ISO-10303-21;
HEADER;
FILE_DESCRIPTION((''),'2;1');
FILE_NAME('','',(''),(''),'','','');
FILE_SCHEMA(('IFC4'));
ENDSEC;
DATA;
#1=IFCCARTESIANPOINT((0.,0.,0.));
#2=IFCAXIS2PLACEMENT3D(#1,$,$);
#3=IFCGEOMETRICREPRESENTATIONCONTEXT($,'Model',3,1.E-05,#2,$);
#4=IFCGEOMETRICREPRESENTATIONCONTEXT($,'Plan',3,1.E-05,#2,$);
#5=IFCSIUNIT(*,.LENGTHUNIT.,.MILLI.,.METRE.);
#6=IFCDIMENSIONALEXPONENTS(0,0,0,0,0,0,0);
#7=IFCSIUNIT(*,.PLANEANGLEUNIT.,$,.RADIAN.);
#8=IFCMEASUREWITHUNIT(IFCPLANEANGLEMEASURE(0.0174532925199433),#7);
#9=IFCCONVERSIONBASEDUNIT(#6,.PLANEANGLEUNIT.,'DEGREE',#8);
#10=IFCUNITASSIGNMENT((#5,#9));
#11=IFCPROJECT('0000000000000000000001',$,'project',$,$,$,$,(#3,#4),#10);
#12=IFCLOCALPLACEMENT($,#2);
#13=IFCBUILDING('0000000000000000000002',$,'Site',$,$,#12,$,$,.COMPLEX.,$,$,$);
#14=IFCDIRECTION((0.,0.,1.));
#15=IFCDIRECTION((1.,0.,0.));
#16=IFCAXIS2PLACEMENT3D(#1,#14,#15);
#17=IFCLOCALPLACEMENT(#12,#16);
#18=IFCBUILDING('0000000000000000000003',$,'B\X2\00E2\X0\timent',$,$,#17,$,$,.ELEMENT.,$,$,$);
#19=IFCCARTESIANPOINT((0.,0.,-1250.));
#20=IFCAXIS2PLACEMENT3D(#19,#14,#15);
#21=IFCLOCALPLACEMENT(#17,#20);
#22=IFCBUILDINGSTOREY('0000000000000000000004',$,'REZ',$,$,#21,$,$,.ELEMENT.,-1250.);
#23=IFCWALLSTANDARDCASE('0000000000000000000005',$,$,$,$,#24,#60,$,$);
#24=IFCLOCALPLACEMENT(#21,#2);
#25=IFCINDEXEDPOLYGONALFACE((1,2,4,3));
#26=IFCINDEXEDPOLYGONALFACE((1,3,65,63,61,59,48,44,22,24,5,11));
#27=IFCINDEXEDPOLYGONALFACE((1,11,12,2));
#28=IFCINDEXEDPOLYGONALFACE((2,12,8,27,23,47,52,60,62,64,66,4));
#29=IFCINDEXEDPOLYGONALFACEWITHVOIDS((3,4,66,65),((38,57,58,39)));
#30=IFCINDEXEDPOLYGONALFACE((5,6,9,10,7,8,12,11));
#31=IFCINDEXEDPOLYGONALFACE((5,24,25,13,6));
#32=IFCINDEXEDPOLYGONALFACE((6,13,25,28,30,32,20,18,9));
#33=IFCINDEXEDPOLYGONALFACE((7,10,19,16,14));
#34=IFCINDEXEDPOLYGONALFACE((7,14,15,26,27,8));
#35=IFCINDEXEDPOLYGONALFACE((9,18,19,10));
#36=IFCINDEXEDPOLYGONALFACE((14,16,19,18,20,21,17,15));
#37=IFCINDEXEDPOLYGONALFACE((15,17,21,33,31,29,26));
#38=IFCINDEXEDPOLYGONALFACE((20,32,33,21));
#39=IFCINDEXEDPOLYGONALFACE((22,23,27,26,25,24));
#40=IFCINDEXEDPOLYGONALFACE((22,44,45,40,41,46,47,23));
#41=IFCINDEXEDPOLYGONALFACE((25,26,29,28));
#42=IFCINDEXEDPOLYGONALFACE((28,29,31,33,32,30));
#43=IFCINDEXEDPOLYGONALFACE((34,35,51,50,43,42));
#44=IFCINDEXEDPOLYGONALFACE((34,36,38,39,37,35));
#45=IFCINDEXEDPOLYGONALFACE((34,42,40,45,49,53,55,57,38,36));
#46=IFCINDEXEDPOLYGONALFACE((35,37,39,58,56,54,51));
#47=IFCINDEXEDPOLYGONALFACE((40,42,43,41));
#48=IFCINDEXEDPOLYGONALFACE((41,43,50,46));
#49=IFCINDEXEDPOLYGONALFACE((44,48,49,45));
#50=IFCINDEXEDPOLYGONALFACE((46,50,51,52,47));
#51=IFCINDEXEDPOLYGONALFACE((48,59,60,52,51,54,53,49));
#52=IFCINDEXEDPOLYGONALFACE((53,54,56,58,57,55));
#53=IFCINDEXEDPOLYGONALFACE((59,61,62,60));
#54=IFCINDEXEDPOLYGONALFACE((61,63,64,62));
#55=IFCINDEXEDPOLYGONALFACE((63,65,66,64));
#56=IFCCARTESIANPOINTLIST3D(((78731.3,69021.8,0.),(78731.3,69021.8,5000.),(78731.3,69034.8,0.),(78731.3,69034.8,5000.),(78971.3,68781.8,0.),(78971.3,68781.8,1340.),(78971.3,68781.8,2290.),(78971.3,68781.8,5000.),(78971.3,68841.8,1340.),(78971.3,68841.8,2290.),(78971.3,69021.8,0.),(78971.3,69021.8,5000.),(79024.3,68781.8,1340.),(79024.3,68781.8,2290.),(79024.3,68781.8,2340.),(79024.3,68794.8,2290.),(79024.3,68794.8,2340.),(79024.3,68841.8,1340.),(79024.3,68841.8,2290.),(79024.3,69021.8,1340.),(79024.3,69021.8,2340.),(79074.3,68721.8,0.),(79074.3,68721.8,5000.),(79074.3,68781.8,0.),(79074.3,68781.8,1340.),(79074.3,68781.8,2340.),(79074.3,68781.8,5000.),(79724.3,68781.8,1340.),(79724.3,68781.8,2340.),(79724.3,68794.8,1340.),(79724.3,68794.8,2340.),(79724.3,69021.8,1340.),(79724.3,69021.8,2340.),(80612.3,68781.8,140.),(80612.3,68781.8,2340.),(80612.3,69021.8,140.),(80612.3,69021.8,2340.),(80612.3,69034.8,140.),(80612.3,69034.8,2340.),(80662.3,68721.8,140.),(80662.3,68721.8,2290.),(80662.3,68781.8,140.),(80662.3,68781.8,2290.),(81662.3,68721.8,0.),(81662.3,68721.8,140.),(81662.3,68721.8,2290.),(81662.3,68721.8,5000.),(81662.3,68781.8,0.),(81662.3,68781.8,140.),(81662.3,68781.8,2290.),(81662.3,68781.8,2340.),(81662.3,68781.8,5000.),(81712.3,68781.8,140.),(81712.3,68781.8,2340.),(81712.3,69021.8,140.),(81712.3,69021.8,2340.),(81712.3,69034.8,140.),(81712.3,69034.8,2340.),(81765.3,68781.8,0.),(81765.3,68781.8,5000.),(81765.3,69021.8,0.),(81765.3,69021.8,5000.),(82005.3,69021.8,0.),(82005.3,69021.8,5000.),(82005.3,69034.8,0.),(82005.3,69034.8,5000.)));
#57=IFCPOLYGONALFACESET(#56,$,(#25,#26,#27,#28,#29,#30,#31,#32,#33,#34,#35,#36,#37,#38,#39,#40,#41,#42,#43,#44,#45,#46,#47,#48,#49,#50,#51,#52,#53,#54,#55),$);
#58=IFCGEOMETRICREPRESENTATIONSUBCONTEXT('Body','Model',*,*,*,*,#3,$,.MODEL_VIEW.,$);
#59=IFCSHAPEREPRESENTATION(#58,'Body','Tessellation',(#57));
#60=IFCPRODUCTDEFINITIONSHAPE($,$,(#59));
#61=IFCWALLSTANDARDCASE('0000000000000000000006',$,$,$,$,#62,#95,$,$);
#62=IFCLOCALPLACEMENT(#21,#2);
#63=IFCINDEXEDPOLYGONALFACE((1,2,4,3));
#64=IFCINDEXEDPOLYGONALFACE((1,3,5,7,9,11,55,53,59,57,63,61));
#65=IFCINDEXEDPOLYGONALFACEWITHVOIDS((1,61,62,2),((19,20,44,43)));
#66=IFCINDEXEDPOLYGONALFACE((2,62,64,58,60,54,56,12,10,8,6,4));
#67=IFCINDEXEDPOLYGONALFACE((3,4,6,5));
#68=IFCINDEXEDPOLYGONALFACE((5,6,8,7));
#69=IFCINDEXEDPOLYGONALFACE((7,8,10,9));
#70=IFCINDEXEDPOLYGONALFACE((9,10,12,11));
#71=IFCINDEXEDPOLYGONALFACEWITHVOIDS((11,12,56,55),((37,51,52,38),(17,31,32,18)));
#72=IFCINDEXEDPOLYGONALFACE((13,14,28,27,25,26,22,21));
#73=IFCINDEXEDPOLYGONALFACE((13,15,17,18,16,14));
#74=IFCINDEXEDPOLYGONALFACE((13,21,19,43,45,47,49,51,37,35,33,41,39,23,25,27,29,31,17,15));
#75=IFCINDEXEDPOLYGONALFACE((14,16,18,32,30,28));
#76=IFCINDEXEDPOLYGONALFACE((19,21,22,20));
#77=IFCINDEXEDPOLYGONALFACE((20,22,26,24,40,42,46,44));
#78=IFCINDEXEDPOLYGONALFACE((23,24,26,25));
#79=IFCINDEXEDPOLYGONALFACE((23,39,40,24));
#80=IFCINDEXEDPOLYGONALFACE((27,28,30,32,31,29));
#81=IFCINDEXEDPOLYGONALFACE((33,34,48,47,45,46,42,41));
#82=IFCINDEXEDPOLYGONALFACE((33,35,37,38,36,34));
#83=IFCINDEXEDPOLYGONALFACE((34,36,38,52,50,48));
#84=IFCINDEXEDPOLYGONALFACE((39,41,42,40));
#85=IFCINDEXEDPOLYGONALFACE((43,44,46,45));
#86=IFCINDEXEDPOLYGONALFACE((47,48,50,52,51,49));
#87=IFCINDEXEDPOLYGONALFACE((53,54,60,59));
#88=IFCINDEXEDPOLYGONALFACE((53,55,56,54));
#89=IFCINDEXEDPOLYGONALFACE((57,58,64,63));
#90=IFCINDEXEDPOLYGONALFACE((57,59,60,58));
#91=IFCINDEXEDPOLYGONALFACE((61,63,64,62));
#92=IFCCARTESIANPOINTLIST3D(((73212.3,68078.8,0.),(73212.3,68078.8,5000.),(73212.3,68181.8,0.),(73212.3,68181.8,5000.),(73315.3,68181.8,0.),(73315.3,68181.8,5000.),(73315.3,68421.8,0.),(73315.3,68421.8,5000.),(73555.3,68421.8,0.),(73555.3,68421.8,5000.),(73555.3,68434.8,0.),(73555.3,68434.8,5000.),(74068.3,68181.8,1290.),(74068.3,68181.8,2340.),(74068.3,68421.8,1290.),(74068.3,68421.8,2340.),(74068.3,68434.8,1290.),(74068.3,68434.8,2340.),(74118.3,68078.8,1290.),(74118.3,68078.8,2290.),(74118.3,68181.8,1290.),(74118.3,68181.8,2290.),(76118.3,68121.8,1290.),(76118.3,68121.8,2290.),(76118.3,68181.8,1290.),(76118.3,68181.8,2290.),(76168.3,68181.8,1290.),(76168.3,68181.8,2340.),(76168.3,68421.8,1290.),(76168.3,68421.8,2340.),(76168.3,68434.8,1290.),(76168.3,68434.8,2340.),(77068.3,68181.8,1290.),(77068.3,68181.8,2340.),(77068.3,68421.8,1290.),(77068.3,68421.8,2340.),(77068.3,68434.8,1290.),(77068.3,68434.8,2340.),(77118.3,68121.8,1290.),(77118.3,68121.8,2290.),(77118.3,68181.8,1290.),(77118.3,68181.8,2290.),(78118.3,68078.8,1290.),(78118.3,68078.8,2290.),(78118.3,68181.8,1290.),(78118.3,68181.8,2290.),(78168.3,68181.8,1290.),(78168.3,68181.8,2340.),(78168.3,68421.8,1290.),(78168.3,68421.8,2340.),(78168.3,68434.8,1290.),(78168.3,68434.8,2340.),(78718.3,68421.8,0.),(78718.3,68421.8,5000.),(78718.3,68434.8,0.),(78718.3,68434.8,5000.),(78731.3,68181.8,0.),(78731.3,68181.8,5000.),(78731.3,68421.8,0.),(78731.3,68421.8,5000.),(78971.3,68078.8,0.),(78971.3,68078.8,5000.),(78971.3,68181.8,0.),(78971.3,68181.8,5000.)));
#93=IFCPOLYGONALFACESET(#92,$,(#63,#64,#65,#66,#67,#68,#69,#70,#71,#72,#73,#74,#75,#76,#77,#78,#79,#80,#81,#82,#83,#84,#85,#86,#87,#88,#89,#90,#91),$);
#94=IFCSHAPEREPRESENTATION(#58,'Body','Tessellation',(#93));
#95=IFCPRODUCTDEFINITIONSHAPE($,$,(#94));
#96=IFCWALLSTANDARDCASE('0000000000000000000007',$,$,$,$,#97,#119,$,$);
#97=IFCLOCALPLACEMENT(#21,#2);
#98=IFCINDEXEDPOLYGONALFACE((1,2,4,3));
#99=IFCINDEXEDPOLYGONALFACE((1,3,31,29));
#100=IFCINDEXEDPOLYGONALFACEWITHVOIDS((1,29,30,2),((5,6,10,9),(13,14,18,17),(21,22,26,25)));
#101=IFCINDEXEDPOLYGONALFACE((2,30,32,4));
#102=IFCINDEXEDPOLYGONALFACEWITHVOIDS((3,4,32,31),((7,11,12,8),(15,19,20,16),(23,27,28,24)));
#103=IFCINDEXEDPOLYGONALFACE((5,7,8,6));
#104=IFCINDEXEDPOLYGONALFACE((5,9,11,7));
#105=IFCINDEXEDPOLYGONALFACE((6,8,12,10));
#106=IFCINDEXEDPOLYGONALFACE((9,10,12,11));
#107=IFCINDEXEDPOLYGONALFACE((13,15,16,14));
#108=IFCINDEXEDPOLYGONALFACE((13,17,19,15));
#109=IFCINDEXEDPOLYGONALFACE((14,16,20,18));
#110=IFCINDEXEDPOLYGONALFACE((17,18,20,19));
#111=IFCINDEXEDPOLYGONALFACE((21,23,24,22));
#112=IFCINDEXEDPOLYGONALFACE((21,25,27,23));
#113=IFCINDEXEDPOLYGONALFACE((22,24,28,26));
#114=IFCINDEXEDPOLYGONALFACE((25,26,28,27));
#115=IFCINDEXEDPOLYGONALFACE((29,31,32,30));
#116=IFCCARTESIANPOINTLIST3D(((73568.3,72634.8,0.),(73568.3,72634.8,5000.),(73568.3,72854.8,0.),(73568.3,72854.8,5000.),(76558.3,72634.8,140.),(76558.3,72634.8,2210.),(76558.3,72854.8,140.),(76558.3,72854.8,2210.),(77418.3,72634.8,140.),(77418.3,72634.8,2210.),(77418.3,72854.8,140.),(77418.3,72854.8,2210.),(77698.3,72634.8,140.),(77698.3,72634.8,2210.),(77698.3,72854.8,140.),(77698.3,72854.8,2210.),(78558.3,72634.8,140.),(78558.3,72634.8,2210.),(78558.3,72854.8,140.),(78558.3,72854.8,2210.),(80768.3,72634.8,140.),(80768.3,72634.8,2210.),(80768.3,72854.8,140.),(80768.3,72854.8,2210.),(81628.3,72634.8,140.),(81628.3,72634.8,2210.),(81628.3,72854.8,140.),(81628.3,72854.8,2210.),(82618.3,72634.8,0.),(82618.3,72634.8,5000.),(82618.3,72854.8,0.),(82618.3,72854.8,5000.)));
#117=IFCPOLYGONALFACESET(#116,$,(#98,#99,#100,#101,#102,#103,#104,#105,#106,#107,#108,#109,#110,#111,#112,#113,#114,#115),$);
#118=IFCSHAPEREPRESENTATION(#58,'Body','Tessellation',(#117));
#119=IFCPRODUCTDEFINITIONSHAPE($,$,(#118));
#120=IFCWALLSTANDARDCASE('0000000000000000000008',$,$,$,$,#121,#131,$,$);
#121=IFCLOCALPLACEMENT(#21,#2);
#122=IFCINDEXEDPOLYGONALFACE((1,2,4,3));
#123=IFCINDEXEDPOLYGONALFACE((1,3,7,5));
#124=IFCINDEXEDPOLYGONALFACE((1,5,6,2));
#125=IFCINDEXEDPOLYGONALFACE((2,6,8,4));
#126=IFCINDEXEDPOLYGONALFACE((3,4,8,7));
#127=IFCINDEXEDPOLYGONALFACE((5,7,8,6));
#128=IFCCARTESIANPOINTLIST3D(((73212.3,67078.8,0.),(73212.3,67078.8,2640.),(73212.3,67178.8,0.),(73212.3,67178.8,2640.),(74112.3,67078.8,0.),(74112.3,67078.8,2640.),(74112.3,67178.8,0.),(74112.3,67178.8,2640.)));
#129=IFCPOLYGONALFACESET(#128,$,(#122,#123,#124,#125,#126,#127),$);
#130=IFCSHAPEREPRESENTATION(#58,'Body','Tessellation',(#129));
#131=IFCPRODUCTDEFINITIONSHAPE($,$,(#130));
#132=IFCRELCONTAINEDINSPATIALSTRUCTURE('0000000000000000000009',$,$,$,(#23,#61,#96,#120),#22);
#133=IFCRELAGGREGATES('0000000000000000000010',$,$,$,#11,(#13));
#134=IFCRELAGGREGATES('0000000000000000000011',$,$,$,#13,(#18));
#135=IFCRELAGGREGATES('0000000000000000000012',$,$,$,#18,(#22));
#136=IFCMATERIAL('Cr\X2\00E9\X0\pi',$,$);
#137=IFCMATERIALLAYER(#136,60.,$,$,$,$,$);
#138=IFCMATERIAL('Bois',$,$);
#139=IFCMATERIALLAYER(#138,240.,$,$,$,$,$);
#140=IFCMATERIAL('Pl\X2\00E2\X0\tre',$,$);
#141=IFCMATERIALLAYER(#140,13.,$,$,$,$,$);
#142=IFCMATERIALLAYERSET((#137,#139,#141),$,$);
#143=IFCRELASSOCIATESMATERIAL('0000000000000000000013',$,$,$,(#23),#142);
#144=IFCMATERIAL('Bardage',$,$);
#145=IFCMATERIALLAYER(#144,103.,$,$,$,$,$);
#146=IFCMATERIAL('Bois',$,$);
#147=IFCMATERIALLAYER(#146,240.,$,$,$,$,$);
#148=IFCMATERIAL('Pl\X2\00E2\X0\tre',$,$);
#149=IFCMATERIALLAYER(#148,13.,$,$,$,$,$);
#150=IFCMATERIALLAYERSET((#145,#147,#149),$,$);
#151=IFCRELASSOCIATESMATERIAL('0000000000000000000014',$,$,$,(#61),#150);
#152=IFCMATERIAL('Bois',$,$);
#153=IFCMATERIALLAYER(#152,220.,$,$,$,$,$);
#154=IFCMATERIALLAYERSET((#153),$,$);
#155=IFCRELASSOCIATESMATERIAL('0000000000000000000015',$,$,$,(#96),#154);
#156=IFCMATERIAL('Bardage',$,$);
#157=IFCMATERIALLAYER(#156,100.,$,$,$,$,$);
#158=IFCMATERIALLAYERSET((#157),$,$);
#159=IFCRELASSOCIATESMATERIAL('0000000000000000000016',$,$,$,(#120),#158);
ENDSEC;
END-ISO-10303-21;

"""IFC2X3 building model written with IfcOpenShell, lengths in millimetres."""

from ifc_helpers import new_model, entity, si_unit, converted_unit, frame, frame_2d, origin, origin_with_axes, place, context, subcontext, project, spatial, polyline, rectangle, outline, extrude, material, layer, layer_set, layer_usage, element, save


model = new_model("IFC2X3")

# Units and contexts
model_context = context("Model", 3, precision=1e-05, world=origin())
plan_context = context("Plan", 3, precision=1e-05, world=origin())
body_context = subcontext(model_context, "Body", "Model", "MODEL_VIEW")
ifc_project = project(units=[si_unit("LENGTHUNIT", "METRE", prefix="MILLI"), converted_unit("PLANEANGLEUNIT", "DEGREE", entity("IfcPlaneAngleMeasure", 0.0174532925199433), si_unit("PLANEANGLEUNIT", "RADIAN"), dimensions=[0, 0, 0, 0, 0, 0, 0])], contexts=[model_context, plan_context])

# Buildings, storey
building_1_placement = place(None, origin())
building_1 = spatial("IfcBuilding", under=ifc_project, at=building_1_placement, Name="Site", CompositionType="COMPLEX")
building_2_placement = place(building_1_placement, origin_with_axes())
building_2 = spatial("IfcBuilding", under=building_1, at=building_2_placement, Name="Bâtiment", CompositionType="ELEMENT")
storey_placement = place(building_2_placement, frame((0.0, 0.0, -1250.0), z_axis=(0.0, 0.0, 1.0), x_axis=(1.0, 0.0, 0.0)))
storey = spatial("IfcBuildingStorey", under=building_2, at=storey_placement, Name="REZ", CompositionType="ELEMENT", Elevation=-1250.0)

# Walls, openings
ifc_material_1 = material(Name="Crépi")
ifc_layer_1 = layer(ifc_material_1, 60.0)
ifc_material_2 = material(Name="Bois")
ifc_layer_2 = layer(ifc_material_2, 240.0)
ifc_material_3 = material(Name="Plâtre")
ifc_layer_3 = layer(ifc_material_3, 13.0)
ifc_layer_set_1 = layer_set([ifc_layer_1, ifc_layer_2, ifc_layer_3])
ifc_layer_usage_1 = layer_usage(ifc_layer_set_1, "AXIS2", "POSITIVE", 0.0)
wall_1_placement = place(storey_placement, frame((79074.3, 68721.8, 0.0), z_axis=(0.0, 0.0, 1.0), x_axis=(1.0, 0.0, 0.0)))
wall_1 = element("IfcWallStandardCase", 1, at=wall_1_placement, inside=storey, material=ifc_layer_usage_1, context=body_context, shape_type="SweptSolid", body=[
    extrude(outline(polyline([(0.0, 0.0), (2588.0, 0.0), (2588.0, 60.0), (2691.0, 60.0), (2691.0, 300.0), (2931.0, 300.0), (2931.0, 313.0), (-343.0, 313.0), (-343.0, 300.0), (-103.0, 300.0), (-103.0, 60.0), (0.0, 60.0), (0.0, 0.0)])), origin_with_axes(), (0.0, 0.0, 1.0), 5000.0),
])
opening_1_placement = place(wall_1_placement, frame((1588.0, 0.0, 140.0), z_axis=(0.0, 1.0, 0.0), x_axis=(0.0, 0.0, 1.0)))
element("IfcOpeningElement", 2, at=opening_1_placement, cuts=wall_1, ObjectType="Opening", context=body_context, shape_type="SweptSolid", body=[
    extrude(rectangle(XDim=2150.0, YDim=1000.0, at=frame_2d((1075.0, 500.0), x_axis=(1.0, 0.0))), origin_with_axes(), (0.0, 0.0, 1.0), 60.0),
    extrude(rectangle(XDim=2200.0, YDim=1100.0, at=frame_2d((1100.0, 550.0), x_axis=(1.0, 0.0))), frame((0.0, -50.0, 60.0), z_axis=(0.0, 0.0, 1.0), x_axis=(1.0, 0.0, 0.0)), (0.0, 0.0, 1.0), 240.0),
    extrude(rectangle(XDim=2200.0, YDim=1100.0, at=frame_2d((1100.0, 550.0), x_axis=(1.0, 0.0))), frame((0.0, -50.0, 300.0), z_axis=(0.0, 0.0, 1.0), x_axis=(1.0, 0.0, 0.0)), (0.0, 0.0, 1.0), 13.0),
])
opening_2_placement = place(wall_1_placement, frame((-50.0, 60.0, 1340.0), z_axis=(0.0, 1.0, 0.0), x_axis=(0.0, 0.0, 1.0)))
element("IfcOpeningElement", 3, at=opening_2_placement, cuts=wall_1, ObjectType="Opening", context=body_context, shape_type="SweptSolid", body=[
    extrude(rectangle(XDim=1000.0, YDim=700.0, at=frame_2d((500.0, 350.0), x_axis=(1.0, 0.0))), origin_with_axes(), (0.0, 0.0, 1.0), 13.0),
    extrude(rectangle(XDim=1000.0, YDim=700.0, at=frame_2d((500.0, 350.0), x_axis=(1.0, 0.0))), frame((0.0, 0.0, 0.0), z_axis=(0.0, 0.0, 1.0), x_axis=(1.0, 0.0, 0.0)), (0.0, 0.0, 1.0), 240.0),
    extrude(rectangle(XDim=950.0, YDim=600.0, at=frame_2d((475.0, 300.0), x_axis=(1.0, 0.0))), frame((0.0, -78.1, 0.0), z_axis=(0.0, 0.0, 1.0), x_axis=(1.0, 0.0, 0.0)), (0.0, 0.0, 1.0), 60.0),
])
ifc_material_4 = material(Name="Bardage")
ifc_layer_4 = layer(ifc_material_4, 103.0)
ifc_material_5 = material(Name="Bois")
ifc_layer_5 = layer(ifc_material_5, 240.0)
ifc_material_6 = material(Name="Plâtre")
ifc_layer_6 = layer(ifc_material_6, 13.0)
ifc_layer_set_2 = layer_set([ifc_layer_4, ifc_layer_5, ifc_layer_6])
ifc_layer_usage_2 = layer_usage(ifc_layer_set_2, "AXIS2", "POSITIVE", 0.0)
wall_2_placement = place(storey_placement, frame((73212.3, 68078.8, 0.0), z_axis=(0.0, 0.0, 1.0), x_axis=(1.0, 0.0, 0.0)))
wall_2 = element("IfcWallStandardCase", 4, at=wall_2_placement, inside=storey, material=ifc_layer_usage_2, context=body_context, shape_type="SweptSolid", body=[
    extrude(outline(polyline([(0.0, 0.0), (5759.0, 0.0), (5759.0, 103.0), (5519.0, 103.0), (5519.0, 343.0), (5506.0, 343.0), (5506.0, 356.0), (343.0, 356.0), (343.0, 343.0), (103.0, 343.0), (103.0, 103.0), (0.0, 103.0), (0.0, 0.0)])), origin_with_axes(), (0.0, 0.0, 1.0), 5000.0),
])
opening_3_placement = place(wall_2_placement, frame((2906.0, 0.0, 1290.0), z_axis=(0.0, 1.0, 0.0), x_axis=(0.0, 0.0, 1.0)))
element("IfcOpeningElement", 5, at=opening_3_placement, cuts=wall_2, ObjectType="Recess", context=body_context, shape_type="SweptSolid", body=[
    extrude(rectangle(XDim=1000.0, YDim=1000.0, at=frame_2d((500.0, 500.0), x_axis=(1.0, 0.0))), origin_with_axes(), (0.0, 0.0, 1.0), 43.0),
])
opening_4_placement = place(wall_2_placement, frame((906.0, 0.0, 1290.0), z_axis=(0.0, 1.0, 0.0), x_axis=(0.0, 0.0, 1.0)))
element("IfcOpeningElement", 6, at=opening_4_placement, cuts=wall_2, ObjectType="Opening", context=body_context, shape_type="SweptSolid", body=[
    extrude(rectangle(XDim=1000.0, YDim=2000.0, at=frame_2d((500.0, 1000.0), x_axis=(1.0, 0.0))), origin_with_axes(), (0.0, 0.0, 1.0), 103.0),
    extrude(rectangle(XDim=1050.0, YDim=2100.0, at=frame_2d((525.0, 1050.0), x_axis=(1.0, 0.0))), frame((0.0, -50.0, 103.0), z_axis=(0.0, 0.0, 1.0), x_axis=(1.0, 0.0, 0.0)), (0.0, 0.0, 1.0), 240.0),
    extrude(rectangle(XDim=1050.0, YDim=2100.0, at=frame_2d((525.0, 1050.0), x_axis=(1.0, 0.0))), frame((0.0, -50.0, 343.0), z_axis=(0.0, 0.0, 1.0), x_axis=(1.0, 0.0, 0.0)), (0.0, 0.0, 1.0), 13.0),
])
opening_5_placement = place(wall_2_placement, frame((3906.0, 0.0, 1290.0), z_axis=(0.0, 1.0, 0.0), x_axis=(0.0, 0.0, 1.0)))
element("IfcOpeningElement", 7, at=opening_5_placement, cuts=wall_2, ObjectType="Opening", context=body_context, shape_type="SweptSolid", body=[
    extrude(rectangle(XDim=1000.0, YDim=1000.0, at=frame_2d((500.0, 500.0), x_axis=(1.0, 0.0))), origin_with_axes(), (0.0, 0.0, 1.0), 103.0),
    extrude(rectangle(XDim=1050.0, YDim=1100.0, at=frame_2d((525.0, 550.0), x_axis=(1.0, 0.0))), frame((0.0, -50.0, 103.0), z_axis=(0.0, 0.0, 1.0), x_axis=(1.0, 0.0, 0.0)), (0.0, 0.0, 1.0), 240.0),
    extrude(rectangle(XDim=1050.0, YDim=1100.0, at=frame_2d((525.0, 550.0), x_axis=(1.0, 0.0))), frame((0.0, -50.0, 343.0), z_axis=(0.0, 0.0, 1.0), x_axis=(1.0, 0.0, 0.0)), (0.0, 0.0, 1.0), 13.0),
])
ifc_material_7 = material(Name="Bois")
ifc_layer_7 = layer(ifc_material_7, 220.0)
ifc_layer_set_3 = layer_set([ifc_layer_7])
ifc_layer_usage_3 = layer_usage(ifc_layer_set_3, "AXIS2", "POSITIVE", 0.0)
wall_3_placement = place(storey_placement, frame((73568.3, 72634.8, 0.0), z_axis=(0.0, 0.0, 1.0), x_axis=(1.0, 0.0, 0.0)))
wall_3 = element("IfcWallStandardCase", 8, at=wall_3_placement, inside=storey, material=ifc_layer_usage_3, context=body_context, shape_type="SweptSolid", body=[
    extrude(rectangle(XDim=9050.0, YDim=220.0, at=frame_2d((4525.0, 110.0), x_axis=(1.0, 0.0))), origin_with_axes(), (0.0, 0.0, 1.0), 5000.0),
])
opening_6_placement = place(wall_3_placement, frame((7200.0, 0.0, 140.0), z_axis=(0.0, 1.0, 0.0), x_axis=(0.0, 0.0, 1.0)))
element("IfcOpeningElement", 9, at=opening_6_placement, cuts=wall_3, ObjectType="Opening", context=body_context, shape_type="SweptSolid", body=[
    extrude(rectangle(XDim=2070.0, YDim=860.0, at=frame_2d((1035.0, 430.0), x_axis=(1.0, 0.0))), origin_with_axes(), (0.0, 0.0, 1.0), 220.0),
])
opening_7_placement = place(wall_3_placement, frame((4130.0, 0.0, 140.0), z_axis=(0.0, 1.0, 0.0), x_axis=(0.0, 0.0, 1.0)))
element("IfcOpeningElement", 10, at=opening_7_placement, cuts=wall_3, ObjectType="Opening", context=body_context, shape_type="SweptSolid", body=[
    extrude(rectangle(XDim=2070.0, YDim=860.0, at=frame_2d((1035.0, 430.0), x_axis=(1.0, 0.0))), origin_with_axes(), (0.0, 0.0, 1.0), 220.0),
])
opening_8_placement = place(wall_3_placement, frame((2990.0, 0.0, 140.0), z_axis=(0.0, 1.0, 0.0), x_axis=(0.0, 0.0, 1.0)))
element("IfcOpeningElement", 11, at=opening_8_placement, cuts=wall_3, ObjectType="Opening", context=body_context, shape_type="SweptSolid", body=[
    extrude(rectangle(XDim=2070.0, YDim=860.0, at=frame_2d((1035.0, 430.0), x_axis=(1.0, 0.0))), origin_with_axes(), (0.0, 0.0, 1.0), 220.0),
])

# Wall
ifc_material_8 = material(Name="Bardage")
ifc_layer_8 = layer(ifc_material_8, 100.0)
ifc_layer_set_4 = layer_set([ifc_layer_8])
ifc_layer_usage_4 = layer_usage(ifc_layer_set_4, "AXIS2", "POSITIVE", 0.0)
wall_4_placement = place(storey_placement, frame((73212.3, 67078.8, 0.0), z_axis=(0.0, 0.0, 1.0), x_axis=(1.0, 0.0, 0.0)))
element("IfcWallStandardCase", 12, at=wall_4_placement, inside=storey, material=ifc_layer_usage_4, context=body_context, shape_type="SweptSolid", body=[
    extrude(rectangle(XDim=900.0, YDim=100.0, at=frame_2d((450.0, 50.0), x_axis=(1.0, 0.0))), origin_with_axes(), (0.0, 0.0, 1.0), 2640.0),
])

save(model, "model.ifc")
